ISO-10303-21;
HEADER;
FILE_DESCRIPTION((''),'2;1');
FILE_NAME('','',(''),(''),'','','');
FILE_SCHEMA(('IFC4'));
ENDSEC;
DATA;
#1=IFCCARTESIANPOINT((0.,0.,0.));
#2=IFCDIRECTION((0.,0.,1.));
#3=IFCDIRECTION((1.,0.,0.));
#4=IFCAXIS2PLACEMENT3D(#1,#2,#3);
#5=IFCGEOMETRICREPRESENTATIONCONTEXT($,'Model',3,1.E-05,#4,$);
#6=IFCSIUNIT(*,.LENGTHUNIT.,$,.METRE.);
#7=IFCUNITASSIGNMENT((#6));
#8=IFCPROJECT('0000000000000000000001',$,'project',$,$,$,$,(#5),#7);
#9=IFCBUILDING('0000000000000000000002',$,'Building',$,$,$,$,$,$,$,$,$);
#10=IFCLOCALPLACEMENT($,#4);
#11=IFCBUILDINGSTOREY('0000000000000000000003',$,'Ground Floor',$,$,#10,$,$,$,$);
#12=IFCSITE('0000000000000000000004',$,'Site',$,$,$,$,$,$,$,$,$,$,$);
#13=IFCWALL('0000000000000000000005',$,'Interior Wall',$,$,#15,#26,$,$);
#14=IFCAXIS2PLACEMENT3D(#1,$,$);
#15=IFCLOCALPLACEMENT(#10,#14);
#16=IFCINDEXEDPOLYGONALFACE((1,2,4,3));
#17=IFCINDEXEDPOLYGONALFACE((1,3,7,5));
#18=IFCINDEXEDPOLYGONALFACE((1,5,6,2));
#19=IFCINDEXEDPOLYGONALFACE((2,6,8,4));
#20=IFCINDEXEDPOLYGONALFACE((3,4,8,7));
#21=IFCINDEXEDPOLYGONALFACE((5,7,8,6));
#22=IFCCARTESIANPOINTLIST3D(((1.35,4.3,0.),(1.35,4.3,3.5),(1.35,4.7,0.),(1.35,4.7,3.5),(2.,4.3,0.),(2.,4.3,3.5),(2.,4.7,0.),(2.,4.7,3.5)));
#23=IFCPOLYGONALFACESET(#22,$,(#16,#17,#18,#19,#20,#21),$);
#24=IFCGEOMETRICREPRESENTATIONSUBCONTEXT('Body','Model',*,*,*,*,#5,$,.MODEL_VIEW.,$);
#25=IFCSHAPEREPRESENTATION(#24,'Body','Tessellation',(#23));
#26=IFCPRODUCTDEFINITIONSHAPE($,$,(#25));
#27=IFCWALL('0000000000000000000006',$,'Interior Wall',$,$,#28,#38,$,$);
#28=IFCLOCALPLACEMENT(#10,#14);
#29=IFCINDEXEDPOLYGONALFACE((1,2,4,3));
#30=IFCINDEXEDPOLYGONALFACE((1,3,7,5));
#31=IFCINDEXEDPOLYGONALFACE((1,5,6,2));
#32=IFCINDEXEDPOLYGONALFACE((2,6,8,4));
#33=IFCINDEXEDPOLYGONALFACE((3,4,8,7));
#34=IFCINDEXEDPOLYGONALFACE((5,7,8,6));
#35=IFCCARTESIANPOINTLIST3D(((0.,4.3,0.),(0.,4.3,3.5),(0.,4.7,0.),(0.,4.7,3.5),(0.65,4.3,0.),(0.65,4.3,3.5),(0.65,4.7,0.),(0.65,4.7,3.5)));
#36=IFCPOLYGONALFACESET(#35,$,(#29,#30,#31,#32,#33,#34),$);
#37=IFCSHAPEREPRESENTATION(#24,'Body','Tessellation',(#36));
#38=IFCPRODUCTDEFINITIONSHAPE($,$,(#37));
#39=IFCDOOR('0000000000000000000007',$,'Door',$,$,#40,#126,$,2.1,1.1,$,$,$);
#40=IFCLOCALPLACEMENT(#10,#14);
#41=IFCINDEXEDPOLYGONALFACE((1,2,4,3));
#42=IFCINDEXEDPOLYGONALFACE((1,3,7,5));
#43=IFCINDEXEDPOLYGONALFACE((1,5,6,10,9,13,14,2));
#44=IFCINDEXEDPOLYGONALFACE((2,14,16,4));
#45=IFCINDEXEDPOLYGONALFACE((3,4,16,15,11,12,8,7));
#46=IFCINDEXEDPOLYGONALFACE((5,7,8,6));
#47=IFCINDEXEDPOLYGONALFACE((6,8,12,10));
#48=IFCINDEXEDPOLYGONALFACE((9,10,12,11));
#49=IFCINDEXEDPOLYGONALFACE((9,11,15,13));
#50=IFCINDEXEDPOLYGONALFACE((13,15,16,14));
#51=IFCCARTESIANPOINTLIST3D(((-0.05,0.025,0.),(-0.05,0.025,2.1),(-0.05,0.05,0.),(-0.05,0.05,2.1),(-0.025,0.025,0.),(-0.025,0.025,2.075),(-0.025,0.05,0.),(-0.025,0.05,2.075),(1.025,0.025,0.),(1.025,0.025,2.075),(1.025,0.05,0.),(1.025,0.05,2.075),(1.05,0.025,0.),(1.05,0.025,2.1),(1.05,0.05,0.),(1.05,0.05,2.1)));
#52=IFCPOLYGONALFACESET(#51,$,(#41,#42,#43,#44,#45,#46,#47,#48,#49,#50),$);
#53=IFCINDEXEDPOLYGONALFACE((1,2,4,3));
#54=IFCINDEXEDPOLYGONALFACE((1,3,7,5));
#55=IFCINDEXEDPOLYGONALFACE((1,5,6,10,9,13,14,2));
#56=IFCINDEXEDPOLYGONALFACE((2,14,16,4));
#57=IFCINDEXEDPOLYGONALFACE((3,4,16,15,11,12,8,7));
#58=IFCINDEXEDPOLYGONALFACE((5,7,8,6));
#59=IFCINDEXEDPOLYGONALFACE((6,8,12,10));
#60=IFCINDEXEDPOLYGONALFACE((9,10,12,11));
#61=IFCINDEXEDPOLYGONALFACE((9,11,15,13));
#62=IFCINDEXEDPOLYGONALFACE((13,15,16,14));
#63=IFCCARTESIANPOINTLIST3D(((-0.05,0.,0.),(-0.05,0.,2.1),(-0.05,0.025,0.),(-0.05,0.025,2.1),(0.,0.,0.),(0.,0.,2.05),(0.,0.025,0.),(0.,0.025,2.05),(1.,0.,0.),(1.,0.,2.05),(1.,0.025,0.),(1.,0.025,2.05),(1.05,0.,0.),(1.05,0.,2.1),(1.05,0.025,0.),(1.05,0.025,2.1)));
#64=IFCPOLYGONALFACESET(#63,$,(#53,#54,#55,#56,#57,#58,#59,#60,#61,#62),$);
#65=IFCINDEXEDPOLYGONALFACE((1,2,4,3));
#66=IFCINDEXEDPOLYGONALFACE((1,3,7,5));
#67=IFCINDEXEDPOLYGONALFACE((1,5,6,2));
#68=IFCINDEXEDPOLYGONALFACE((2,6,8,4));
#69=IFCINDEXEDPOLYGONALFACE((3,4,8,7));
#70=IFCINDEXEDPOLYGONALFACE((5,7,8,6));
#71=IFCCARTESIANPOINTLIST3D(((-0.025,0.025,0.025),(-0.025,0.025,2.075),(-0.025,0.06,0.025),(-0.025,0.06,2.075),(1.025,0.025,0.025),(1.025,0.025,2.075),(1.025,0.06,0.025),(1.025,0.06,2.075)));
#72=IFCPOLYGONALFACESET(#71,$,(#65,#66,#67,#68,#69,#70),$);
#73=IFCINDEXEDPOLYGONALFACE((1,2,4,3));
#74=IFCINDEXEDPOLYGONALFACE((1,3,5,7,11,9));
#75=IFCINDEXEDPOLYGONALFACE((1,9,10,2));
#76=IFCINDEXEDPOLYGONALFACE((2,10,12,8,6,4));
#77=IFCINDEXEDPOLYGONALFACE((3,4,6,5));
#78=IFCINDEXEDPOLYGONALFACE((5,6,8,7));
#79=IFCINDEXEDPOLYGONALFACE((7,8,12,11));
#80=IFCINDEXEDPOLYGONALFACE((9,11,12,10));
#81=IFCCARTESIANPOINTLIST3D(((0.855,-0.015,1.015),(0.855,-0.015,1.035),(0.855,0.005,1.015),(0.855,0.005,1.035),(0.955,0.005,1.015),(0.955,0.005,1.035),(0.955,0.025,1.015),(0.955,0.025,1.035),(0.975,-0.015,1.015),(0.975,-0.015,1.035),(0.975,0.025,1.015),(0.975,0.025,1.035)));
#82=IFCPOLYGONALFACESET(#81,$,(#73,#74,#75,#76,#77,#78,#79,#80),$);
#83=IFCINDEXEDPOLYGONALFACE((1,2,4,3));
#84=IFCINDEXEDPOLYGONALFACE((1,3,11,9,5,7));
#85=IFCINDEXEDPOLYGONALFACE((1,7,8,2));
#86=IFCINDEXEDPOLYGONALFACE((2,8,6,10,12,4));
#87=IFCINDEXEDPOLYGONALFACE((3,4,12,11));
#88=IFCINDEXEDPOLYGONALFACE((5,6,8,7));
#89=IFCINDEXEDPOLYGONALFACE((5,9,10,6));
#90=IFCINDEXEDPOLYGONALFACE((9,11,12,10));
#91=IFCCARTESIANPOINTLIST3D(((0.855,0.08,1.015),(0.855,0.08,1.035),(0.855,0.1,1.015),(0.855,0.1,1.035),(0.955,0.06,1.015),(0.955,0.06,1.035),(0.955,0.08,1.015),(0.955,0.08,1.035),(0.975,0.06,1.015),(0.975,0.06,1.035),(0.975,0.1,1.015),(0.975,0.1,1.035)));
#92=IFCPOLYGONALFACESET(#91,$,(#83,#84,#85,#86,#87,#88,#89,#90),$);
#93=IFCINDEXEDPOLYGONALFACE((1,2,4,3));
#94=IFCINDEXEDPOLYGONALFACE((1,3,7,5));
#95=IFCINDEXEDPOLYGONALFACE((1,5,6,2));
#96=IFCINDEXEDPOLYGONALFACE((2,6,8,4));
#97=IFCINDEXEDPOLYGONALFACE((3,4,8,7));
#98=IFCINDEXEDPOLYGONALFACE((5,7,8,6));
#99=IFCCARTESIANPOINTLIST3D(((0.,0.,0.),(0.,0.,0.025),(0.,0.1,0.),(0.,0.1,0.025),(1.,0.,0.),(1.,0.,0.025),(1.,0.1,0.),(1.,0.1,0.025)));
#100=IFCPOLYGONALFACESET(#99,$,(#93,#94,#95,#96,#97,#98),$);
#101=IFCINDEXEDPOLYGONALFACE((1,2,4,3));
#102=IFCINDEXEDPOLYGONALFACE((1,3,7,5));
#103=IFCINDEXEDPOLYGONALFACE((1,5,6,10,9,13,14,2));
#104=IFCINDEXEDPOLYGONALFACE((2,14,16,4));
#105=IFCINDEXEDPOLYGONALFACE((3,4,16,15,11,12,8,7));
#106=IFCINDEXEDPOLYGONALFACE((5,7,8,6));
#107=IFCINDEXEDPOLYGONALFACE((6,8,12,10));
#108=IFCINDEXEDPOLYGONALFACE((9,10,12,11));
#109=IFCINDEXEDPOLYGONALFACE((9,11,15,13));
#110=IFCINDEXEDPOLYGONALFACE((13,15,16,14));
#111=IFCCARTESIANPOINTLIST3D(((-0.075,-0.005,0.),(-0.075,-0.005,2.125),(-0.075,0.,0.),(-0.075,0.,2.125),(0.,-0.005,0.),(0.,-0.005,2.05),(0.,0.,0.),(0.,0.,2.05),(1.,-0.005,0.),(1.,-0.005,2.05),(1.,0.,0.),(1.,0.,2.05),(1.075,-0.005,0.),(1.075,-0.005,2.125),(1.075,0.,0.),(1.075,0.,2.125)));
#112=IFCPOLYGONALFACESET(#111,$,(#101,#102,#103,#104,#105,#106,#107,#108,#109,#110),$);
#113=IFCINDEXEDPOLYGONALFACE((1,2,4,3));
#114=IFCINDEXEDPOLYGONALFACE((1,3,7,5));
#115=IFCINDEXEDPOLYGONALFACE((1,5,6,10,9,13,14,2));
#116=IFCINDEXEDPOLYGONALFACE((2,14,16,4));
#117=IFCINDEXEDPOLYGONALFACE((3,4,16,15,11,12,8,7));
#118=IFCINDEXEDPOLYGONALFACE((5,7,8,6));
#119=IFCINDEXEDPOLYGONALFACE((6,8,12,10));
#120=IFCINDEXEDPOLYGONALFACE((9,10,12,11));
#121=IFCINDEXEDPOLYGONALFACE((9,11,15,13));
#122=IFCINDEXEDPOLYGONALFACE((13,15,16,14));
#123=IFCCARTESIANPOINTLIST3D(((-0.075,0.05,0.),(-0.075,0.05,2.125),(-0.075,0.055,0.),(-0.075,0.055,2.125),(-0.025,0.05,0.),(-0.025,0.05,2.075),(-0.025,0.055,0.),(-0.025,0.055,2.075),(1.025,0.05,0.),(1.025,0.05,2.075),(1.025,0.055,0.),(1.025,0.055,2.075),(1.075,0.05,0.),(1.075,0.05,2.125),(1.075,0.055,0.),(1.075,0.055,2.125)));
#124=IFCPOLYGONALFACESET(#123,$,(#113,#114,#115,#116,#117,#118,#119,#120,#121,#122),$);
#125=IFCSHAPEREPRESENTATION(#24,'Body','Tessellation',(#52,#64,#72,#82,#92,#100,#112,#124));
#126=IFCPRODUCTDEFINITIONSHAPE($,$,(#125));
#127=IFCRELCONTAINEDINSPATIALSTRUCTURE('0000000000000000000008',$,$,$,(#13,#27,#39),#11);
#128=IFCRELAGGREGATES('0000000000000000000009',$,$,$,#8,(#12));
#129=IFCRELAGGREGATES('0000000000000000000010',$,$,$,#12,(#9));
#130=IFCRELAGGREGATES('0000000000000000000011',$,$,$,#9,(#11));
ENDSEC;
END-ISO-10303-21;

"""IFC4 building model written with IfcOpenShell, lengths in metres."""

from ifc_helpers import new_model, si_unit, frame, origin_with_axes, place, context, subcontext, project, spatial, line, indexed_curve, outline, extrude, element, save


model = new_model("IFC4")

# Units and contexts
model_context = context("Model", 3, precision=1e-05, world=origin_with_axes())
body_context = subcontext(model_context, "Body", "Model", "MODEL_VIEW")
ifc_project = project(units=[si_unit("LENGTHUNIT", "METRE")], contexts=[model_context])

# Site, building, storey
site = spatial("IfcSite", under=ifc_project, Name="Site")
building = spatial("IfcBuilding", under=site, Name="Building")
storey_placement = place(None, origin_with_axes())
storey = spatial("IfcBuildingStorey", under=building, at=storey_placement, Name="Ground Floor")

# Walls
for number, where, z_axis, x_axis, name in (
    (1, (2.0, 4.5, 0.0), (0.0, 0.0, 1.0), (-1.0, 0.0, 0.0), "Interior Wall"),
    (2, (0.65, 4.5, 0.0), (0.0, 0.0, 1.0), (-1.0, 0.0, 0.0), "Interior Wall"),
):
    element("IfcWall", number, at=place(storey_placement, frame(where, z_axis=z_axis, x_axis=x_axis)), inside=storey, Name=name, context=body_context, shape_type="SweptSolid", body=[
        extrude(outline(indexed_curve([(0.0, 0.0), (0.0, 0.4), (0.65, 0.4), (0.65, 0.0), (0.0, 0.0)], self_intersect=False)), frame((0.0, -0.2, 0.0), z_axis=(0.0, 0.0, 1.0), x_axis=(1.0, 0.0, 0.0)), (0.0, 0.0, 1.0), 3.5),
    ])

# Door
door_1_placement = place(storey_placement, frame((-0.05, 0.0, 0.0), z_axis=(0.0, 0.0, 1.0), x_axis=(1.0, 0.0, 0.0)))
element("IfcDoor", 3, at=door_1_placement, inside=storey, Name="Door", OverallHeight=2.1, OverallWidth=1.1, context=body_context, shape_type="SweptSolid", body=[
    extrude(outline(indexed_curve([(0.0, 0.0), (0.0, 2.1), (1.1, 2.1), (1.1, 0.0), (1.075, 0.0), (1.075, 2.075), (0.025, 2.075), (0.025, 0.0)], segments=[line(1, 2, 3, 4, 5, 6, 7, 8, 1)])), frame((0.0, 0.025, 0.0), z_axis=(0.0, -1.0, 0.0), x_axis=(1.0, 0.0, 0.0)), (0.0, 0.0, -1.0), 0.025),
    extrude(outline(indexed_curve([(0.0, 0.0), (0.0, 2.1), (1.1, 2.1), (1.1, 0.0), (1.05, 0.0), (1.05, 2.05), (0.05, 2.05), (0.05, 0.0)], segments=[line(1, 2, 3, 4, 5, 6, 7, 8, 1)])), frame((0.0, 0.0, 0.0), z_axis=(0.0, -1.0, 0.0), x_axis=(1.0, 0.0, 0.0)), (0.0, 0.0, -1.0), 0.025),
    extrude(outline(indexed_curve([(0.0, 0.0), (1.05, 0.0), (1.05, 0.035), (0.0, 0.035)], segments=[line(1, 2, 3, 4, 1)])), frame((0.025, 0.025, 0.025), z_axis=(0.0, 0.0, 1.0), x_axis=(1.0, 0.0, 0.0)), (0.0, 0.0, 1.0), 2.05),
    extrude(outline(indexed_curve([(0.0, 0.0), (0.0, -0.04), (-0.12, -0.04), (-0.12, -0.02), (-0.02, -0.02), (-0.02, 0.0)], segments=[line(1, 2, 3, 4, 5, 6, 1)])), frame((1.025, 0.025, 1.015), z_axis=(0.0, 0.0, 1.0), x_axis=(1.0, 0.0, 0.0)), (0.0, 0.0, 1.0), 0.02),
    extrude(outline(indexed_curve([(0.0, 0.0), (0.0, 0.04), (-0.12, 0.04), (-0.12, 0.02), (-0.02, 0.02), (-0.02, 0.0)], segments=[line(1, 2, 3, 4, 5, 6, 1)])), frame((1.025, 0.06, 1.015), z_axis=(0.0, 0.0, 1.0), x_axis=(1.0, 0.0, 0.0)), (0.0, 0.0, 1.0), 0.02),
    extrude(outline(indexed_curve([(0.0, 0.0), (1.0, 0.0), (1.0, 0.1), (0.0, 0.1)], segments=[line(1, 2, 3, 4, 1)])), frame((0.05, 0.0, 0.0), z_axis=(0.0, 0.0, 1.0), x_axis=(1.0, 0.0, 0.0)), (0.0, 0.0, 1.0), 0.025),
    extrude(outline(indexed_curve([(0.0, 0.0), (0.0, 2.125), (1.15, 2.125), (1.15, 0.0), (1.075, 0.0), (1.075, 2.05), (0.075, 2.05), (0.075, 0.0)], segments=[line(1, 2, 3, 4, 5, 6, 7, 8, 1)])), frame((-0.025, -0.005, 0.0), z_axis=(0.0, -1.0, 0.0), x_axis=(1.0, 0.0, 0.0)), (0.0, 0.0, -1.0), 0.005),
    extrude(outline(indexed_curve([(0.0, 0.0), (0.0, 2.125), (1.15, 2.125), (1.15, 0.0), (1.1, 0.0), (1.1, 2.075), (0.05, 2.075), (0.05, 0.0)], segments=[line(1, 2, 3, 4, 5, 6, 7, 8, 1)])), frame((-0.025, 0.05, 0.0), z_axis=(0.0, -1.0, 0.0), x_axis=(1.0, 0.0, 0.0)), (0.0, 0.0, -1.0), 0.005),
])

save(model, "model.ifc")
